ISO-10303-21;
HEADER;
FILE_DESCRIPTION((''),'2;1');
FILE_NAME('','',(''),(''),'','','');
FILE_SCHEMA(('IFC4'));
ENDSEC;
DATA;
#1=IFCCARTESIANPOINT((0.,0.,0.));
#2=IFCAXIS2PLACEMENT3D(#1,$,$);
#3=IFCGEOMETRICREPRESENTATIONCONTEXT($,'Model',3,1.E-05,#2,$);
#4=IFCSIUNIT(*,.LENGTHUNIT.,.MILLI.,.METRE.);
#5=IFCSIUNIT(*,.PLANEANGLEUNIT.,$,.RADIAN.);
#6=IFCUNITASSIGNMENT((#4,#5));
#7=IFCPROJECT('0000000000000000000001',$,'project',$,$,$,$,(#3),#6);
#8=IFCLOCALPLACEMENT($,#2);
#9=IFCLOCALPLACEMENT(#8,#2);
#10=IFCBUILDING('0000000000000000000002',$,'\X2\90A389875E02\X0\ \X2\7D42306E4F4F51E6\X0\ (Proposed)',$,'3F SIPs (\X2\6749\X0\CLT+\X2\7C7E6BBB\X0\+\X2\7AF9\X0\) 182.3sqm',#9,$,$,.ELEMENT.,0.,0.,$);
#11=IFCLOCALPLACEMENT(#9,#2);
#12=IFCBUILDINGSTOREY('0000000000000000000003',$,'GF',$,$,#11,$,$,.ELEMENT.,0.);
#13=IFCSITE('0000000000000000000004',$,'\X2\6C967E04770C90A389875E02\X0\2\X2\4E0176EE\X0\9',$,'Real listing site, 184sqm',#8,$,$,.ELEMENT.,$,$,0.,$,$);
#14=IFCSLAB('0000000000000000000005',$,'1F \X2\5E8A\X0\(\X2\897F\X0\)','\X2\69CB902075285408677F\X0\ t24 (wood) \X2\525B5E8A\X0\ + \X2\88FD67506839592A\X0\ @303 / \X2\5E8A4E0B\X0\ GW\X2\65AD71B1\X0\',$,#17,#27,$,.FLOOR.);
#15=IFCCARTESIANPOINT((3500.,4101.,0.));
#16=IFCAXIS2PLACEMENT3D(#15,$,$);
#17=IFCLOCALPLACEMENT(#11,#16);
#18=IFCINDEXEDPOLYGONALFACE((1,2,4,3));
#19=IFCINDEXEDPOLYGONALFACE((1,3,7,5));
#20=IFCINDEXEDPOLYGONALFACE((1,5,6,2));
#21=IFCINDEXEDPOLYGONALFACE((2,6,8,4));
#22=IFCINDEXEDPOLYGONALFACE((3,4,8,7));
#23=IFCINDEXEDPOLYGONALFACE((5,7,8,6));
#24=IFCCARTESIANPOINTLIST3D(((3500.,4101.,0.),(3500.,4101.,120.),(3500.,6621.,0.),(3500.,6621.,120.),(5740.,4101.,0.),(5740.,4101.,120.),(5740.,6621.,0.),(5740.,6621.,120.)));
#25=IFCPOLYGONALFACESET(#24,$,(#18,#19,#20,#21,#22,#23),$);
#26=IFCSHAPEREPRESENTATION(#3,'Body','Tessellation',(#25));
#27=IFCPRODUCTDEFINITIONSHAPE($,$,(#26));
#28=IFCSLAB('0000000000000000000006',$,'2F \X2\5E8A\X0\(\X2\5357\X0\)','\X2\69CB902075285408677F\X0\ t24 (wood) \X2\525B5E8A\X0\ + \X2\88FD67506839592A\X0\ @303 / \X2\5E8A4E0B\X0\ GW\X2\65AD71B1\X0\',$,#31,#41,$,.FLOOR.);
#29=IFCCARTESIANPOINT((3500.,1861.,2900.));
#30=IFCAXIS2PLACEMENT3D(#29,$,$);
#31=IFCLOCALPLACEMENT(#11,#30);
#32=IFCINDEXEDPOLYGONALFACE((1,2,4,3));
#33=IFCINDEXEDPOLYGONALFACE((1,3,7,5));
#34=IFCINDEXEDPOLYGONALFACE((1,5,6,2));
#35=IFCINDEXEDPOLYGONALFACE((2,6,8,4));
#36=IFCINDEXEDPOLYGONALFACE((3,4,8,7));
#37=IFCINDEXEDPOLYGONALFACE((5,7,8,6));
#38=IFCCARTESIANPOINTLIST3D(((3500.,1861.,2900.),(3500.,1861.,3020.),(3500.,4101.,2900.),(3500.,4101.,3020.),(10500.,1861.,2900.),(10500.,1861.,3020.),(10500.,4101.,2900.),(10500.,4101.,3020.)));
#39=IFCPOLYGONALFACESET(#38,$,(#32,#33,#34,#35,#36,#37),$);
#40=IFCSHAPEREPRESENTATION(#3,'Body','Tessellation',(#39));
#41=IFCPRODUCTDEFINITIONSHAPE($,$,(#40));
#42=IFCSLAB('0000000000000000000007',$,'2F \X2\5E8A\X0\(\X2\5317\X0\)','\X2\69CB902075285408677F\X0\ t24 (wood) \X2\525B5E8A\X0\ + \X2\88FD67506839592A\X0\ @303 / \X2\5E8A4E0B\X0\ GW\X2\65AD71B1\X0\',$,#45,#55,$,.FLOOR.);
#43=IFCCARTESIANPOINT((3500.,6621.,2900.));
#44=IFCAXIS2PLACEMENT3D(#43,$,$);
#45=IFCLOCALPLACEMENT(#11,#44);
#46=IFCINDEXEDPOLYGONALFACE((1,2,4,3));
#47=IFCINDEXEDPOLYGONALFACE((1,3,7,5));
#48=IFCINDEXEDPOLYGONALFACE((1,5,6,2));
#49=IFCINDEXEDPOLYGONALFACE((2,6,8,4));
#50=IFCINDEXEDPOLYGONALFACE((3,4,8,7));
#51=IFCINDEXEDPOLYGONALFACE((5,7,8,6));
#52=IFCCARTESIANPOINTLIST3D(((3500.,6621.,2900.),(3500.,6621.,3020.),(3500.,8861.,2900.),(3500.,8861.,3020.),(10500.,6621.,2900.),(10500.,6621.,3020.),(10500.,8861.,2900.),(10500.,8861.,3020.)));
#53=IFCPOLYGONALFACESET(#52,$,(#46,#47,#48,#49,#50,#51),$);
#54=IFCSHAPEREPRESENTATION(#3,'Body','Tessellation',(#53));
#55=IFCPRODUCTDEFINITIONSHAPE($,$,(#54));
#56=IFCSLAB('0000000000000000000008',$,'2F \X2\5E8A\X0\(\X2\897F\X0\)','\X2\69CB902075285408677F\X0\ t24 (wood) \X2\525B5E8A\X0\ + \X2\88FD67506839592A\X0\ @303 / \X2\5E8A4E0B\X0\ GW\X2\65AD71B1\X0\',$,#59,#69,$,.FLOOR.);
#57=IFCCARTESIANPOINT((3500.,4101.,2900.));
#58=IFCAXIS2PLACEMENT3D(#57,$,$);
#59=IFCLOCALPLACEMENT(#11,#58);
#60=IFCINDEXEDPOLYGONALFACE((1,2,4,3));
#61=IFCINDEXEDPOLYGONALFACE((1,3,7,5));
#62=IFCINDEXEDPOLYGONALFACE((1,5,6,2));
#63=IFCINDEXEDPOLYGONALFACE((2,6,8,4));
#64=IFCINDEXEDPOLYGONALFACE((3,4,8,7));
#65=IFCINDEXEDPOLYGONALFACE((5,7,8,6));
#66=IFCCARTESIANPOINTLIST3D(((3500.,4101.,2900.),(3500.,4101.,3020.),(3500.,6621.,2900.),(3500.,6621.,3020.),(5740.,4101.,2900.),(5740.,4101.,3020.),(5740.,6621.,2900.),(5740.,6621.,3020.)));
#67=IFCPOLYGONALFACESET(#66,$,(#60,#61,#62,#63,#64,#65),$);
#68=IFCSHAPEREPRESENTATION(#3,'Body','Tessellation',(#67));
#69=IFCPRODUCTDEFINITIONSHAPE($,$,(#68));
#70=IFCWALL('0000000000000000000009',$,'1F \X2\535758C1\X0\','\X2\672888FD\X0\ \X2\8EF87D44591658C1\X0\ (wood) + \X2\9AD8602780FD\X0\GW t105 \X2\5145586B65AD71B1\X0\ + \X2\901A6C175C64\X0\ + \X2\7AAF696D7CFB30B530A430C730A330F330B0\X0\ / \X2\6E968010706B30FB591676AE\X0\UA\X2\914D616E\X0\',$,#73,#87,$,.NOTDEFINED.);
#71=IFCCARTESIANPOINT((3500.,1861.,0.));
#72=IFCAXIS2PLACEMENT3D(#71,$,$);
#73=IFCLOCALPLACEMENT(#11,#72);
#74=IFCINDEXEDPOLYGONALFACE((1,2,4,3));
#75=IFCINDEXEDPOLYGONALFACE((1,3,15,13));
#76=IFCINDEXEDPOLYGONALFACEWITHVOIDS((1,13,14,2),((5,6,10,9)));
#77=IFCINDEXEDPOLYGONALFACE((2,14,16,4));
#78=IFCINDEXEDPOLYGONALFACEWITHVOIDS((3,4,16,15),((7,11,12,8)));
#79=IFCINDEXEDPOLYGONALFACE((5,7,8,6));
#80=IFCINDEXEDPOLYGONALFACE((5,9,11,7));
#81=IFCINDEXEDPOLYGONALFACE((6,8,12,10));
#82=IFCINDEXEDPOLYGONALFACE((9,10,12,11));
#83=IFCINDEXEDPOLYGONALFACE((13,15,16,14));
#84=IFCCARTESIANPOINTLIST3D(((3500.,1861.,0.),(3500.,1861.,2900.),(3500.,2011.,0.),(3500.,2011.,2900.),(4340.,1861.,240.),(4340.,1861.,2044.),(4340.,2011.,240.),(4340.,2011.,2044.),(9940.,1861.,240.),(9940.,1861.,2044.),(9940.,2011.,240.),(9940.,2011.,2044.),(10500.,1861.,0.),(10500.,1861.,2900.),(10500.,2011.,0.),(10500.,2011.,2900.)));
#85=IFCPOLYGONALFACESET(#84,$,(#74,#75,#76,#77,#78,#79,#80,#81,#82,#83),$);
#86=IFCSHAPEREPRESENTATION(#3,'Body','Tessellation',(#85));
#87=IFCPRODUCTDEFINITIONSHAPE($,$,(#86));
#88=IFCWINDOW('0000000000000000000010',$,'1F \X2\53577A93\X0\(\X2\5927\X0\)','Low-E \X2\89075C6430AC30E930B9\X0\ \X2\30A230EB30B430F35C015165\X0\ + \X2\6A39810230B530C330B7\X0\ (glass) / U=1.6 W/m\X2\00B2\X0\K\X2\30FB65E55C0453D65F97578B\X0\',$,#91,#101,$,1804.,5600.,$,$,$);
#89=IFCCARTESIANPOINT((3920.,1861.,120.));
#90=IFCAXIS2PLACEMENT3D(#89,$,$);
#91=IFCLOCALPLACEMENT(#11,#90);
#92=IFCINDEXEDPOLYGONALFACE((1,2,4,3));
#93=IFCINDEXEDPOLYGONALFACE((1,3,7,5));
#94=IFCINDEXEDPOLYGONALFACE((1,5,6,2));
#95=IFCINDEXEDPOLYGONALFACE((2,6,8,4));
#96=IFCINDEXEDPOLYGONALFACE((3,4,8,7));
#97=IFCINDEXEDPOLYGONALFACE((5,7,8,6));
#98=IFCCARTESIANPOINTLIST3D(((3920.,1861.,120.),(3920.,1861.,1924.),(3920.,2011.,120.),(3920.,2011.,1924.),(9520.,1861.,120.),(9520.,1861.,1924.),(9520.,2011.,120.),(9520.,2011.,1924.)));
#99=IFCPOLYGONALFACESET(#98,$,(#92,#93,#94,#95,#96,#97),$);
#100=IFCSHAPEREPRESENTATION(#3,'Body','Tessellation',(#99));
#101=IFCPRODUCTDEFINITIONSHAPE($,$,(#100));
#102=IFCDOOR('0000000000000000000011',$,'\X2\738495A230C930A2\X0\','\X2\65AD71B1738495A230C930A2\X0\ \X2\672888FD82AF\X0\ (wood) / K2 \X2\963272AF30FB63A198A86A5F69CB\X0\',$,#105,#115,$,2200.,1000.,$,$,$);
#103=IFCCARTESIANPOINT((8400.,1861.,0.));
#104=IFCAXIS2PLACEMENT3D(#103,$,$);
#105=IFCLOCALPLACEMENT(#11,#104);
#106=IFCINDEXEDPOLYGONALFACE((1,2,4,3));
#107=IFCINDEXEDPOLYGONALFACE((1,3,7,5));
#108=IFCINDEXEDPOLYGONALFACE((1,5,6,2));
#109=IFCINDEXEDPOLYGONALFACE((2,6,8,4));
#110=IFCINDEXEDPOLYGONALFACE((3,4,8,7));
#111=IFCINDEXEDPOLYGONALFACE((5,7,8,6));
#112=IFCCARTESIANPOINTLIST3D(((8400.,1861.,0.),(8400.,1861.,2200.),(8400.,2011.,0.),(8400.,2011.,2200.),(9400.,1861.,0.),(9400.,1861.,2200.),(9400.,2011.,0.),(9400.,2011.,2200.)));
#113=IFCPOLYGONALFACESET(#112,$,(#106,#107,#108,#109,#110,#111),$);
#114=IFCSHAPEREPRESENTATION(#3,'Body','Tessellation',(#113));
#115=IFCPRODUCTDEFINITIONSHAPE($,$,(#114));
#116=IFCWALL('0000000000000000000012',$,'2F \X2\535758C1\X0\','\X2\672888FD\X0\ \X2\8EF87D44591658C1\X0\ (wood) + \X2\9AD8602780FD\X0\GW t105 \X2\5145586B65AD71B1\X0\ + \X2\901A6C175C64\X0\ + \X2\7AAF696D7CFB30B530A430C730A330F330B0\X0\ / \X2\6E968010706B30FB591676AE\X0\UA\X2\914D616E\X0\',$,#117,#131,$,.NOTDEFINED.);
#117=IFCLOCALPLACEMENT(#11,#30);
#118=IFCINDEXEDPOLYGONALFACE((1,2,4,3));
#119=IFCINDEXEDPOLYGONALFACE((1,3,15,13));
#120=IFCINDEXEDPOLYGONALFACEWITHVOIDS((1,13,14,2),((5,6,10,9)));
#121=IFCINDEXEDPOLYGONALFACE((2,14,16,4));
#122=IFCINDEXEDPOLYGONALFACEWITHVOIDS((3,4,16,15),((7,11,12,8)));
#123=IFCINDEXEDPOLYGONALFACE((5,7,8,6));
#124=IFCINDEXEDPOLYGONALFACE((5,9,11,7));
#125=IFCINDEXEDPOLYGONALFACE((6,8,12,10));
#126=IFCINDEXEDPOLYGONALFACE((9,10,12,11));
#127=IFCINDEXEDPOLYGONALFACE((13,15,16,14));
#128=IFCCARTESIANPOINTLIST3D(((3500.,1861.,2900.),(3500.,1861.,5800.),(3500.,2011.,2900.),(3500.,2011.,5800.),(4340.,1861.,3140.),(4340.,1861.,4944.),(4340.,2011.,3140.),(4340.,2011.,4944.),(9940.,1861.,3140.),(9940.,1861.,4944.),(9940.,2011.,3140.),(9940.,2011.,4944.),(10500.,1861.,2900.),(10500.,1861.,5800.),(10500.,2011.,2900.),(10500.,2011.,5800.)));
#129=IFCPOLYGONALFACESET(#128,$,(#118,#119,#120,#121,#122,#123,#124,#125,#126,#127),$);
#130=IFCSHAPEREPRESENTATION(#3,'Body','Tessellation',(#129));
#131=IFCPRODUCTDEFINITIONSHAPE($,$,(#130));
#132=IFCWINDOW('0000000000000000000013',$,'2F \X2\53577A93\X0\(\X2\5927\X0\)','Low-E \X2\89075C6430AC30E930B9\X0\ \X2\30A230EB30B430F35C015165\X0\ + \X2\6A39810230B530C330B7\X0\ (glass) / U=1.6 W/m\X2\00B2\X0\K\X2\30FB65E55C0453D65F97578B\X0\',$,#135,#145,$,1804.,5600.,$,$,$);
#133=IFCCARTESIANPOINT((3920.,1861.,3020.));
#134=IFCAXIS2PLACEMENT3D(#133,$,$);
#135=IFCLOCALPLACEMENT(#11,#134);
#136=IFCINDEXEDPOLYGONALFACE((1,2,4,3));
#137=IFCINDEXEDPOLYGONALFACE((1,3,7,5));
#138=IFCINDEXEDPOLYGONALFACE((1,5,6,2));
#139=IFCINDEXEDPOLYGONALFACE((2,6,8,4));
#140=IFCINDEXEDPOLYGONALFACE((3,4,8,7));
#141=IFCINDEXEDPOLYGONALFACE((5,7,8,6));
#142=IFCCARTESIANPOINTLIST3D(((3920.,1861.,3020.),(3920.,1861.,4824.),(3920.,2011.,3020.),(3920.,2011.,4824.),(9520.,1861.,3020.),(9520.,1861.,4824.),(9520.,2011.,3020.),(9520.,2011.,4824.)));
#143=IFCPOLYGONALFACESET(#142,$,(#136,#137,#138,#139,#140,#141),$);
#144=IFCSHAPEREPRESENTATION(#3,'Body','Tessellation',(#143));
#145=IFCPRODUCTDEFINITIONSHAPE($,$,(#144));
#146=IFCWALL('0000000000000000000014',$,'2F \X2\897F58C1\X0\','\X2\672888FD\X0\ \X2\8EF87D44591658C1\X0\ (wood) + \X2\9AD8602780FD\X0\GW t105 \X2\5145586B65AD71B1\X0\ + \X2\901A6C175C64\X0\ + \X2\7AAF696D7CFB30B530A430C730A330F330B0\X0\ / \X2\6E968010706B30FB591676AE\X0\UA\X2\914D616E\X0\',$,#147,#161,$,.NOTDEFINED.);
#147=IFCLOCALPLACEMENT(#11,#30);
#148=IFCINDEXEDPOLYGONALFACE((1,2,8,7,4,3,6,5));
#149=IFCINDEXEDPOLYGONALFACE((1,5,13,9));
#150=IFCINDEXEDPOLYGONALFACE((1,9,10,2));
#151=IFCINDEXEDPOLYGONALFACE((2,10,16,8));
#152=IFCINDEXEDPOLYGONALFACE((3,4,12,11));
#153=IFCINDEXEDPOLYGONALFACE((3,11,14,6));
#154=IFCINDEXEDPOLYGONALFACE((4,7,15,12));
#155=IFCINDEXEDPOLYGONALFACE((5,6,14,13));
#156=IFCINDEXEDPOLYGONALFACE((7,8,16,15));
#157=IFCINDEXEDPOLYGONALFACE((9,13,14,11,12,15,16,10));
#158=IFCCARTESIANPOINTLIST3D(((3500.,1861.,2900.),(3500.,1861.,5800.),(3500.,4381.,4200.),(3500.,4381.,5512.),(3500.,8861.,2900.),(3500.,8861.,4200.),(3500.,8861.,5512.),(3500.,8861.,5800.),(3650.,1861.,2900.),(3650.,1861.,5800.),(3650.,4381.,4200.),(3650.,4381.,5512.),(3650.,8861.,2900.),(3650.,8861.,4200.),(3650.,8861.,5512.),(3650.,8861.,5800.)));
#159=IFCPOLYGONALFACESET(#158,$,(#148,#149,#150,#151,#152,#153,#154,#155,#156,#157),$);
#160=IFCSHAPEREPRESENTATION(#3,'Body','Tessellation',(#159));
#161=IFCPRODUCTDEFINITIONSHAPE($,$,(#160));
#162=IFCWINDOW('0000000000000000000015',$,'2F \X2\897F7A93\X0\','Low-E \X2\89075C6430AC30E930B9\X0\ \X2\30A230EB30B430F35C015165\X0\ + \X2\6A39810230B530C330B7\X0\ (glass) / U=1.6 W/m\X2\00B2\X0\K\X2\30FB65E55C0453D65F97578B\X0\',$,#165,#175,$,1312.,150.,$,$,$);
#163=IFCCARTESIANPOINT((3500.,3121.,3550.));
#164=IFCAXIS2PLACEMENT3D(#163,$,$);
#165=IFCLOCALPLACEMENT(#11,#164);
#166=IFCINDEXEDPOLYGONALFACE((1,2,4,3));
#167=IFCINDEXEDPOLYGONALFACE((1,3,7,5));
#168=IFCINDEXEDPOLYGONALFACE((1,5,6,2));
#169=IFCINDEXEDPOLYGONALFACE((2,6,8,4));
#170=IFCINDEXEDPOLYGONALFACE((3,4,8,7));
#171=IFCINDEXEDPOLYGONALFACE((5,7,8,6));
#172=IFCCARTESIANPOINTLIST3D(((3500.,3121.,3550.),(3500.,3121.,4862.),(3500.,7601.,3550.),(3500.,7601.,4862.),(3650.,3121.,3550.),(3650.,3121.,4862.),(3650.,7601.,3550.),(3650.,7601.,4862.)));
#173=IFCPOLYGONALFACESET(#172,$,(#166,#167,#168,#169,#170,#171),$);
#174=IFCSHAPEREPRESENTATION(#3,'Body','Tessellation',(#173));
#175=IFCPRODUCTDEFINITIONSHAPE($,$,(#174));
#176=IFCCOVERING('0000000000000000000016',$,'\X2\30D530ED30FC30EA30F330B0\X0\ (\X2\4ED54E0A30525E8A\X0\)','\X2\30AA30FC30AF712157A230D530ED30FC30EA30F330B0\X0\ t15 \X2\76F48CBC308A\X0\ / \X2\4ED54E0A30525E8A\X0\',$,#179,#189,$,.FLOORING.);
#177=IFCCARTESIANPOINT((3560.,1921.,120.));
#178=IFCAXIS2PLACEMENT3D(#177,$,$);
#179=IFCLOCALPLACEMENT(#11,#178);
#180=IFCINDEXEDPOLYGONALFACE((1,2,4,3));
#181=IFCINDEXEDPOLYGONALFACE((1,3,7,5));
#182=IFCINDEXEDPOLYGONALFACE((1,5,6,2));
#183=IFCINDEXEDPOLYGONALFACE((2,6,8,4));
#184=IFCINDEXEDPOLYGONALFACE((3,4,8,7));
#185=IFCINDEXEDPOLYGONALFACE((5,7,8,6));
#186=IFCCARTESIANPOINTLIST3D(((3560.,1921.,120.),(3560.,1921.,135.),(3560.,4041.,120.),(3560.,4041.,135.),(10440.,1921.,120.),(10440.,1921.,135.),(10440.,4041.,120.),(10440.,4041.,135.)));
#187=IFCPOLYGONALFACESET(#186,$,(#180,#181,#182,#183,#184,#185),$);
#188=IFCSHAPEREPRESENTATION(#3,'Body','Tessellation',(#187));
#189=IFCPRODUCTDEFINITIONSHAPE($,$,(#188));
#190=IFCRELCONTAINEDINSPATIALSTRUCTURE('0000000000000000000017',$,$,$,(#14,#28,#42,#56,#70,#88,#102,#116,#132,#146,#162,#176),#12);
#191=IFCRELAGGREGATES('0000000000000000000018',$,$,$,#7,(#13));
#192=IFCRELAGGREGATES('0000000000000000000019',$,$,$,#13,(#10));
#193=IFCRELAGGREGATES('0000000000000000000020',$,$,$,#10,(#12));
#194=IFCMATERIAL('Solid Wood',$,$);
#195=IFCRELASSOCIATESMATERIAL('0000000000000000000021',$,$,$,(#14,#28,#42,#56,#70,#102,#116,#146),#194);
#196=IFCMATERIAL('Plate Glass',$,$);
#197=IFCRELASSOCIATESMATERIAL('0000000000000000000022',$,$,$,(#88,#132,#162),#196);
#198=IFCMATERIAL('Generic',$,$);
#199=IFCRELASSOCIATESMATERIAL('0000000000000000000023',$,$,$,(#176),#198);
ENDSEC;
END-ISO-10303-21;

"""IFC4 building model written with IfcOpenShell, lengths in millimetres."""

from ifc_helpers import new_model, si_unit, frame, frame_2d, origin, place, context, project, spatial, rectangle, extrude, material, element, fill, save


model = new_model("IFC4")

# Units and contexts
model_context = context("Model", 3, precision=1e-05, world=origin())
ifc_project = project(units=[si_unit("LENGTHUNIT", "METRE", prefix="MILLI"), si_unit("PLANEANGLEUNIT", "RADIAN")], contexts=[model_context])

# Site, building, storey
site_placement = place(None, origin())
site = spatial("IfcSite", under=ifc_project, at=site_placement, Name="沖縄県那覇市2丁目9", ObjectType="Real listing site, 184sqm", CompositionType="ELEMENT", RefElevation=0.0)
building_placement = place(site_placement, origin())
building = spatial("IfcBuilding", under=site, at=building_placement, Name="那覇市 終の住処 (Proposed)", ObjectType="3F SIPs (杉CLT+籾殻+竹) 182.3sqm", CompositionType="ELEMENT", ElevationOfRefHeight=0.0, ElevationOfTerrain=0.0)
storey_placement = place(building_placement, origin())
storey = spatial("IfcBuildingStorey", under=building, at=storey_placement, Name="GF", CompositionType="ELEMENT", Elevation=0.0)

# Slabs
ifc_material_1 = material(Name="Solid Wood")
slab_1_placement = place(storey_placement, frame((3500.0, 4101.0, 0.0)))
element("IfcSlab", 1, at=slab_1_placement, inside=storey, material=ifc_material_1, Name="1F 床(西)", Description="構造用合板 t24 (wood) 剛床 + 製材根太 @303 / 床下 GW断熱", PredefinedType="FLOOR", context=model_context, shape_type="SweptSolid", body=[
    extrude(rectangle(XDim=2240.0, YDim=2520.0, at=frame_2d((1120.0, 1260.0))), frame((3500.0, 4101.0, 0.0)), (0.0, 0.0, 1.0), 120.0),
])
slab_2_placement = place(storey_placement, frame((3500.0, 1861.0, 2900.0)))
element("IfcSlab", 2, at=slab_2_placement, inside=storey, material=ifc_material_1, Name="2F 床(南)", Description="構造用合板 t24 (wood) 剛床 + 製材根太 @303 / 床下 GW断熱", PredefinedType="FLOOR", context=model_context, shape_type="SweptSolid", body=[
    extrude(rectangle(XDim=7000.0, YDim=2240.0, at=frame_2d((3500.0, 1120.0))), frame((3500.0, 1861.0, 2900.0)), (0.0, 0.0, 1.0), 120.0),
])
slab_3_placement = place(storey_placement, frame((3500.0, 6621.0, 2900.0)))
element("IfcSlab", 3, at=slab_3_placement, inside=storey, material=ifc_material_1, Name="2F 床(北)", Description="構造用合板 t24 (wood) 剛床 + 製材根太 @303 / 床下 GW断熱", PredefinedType="FLOOR", context=model_context, shape_type="SweptSolid", body=[
    extrude(rectangle(XDim=7000.0, YDim=2240.0, at=frame_2d((3500.0, 1120.0))), frame((3500.0, 6621.0, 2900.0)), (0.0, 0.0, 1.0), 120.0),
])
slab_4_placement = place(storey_placement, frame((3500.0, 4101.0, 2900.0)))
element("IfcSlab", 4, at=slab_4_placement, inside=storey, material=ifc_material_1, Name="2F 床(西)", Description="構造用合板 t24 (wood) 剛床 + 製材根太 @303 / 床下 GW断熱", PredefinedType="FLOOR", context=model_context, shape_type="SweptSolid", body=[
    extrude(rectangle(XDim=2240.0, YDim=2520.0, at=frame_2d((1120.0, 1260.0))), frame((3500.0, 4101.0, 2900.0)), (0.0, 0.0, 1.0), 120.0),
])

# Wall, openings, window, door
wall_1_placement = place(storey_placement, frame((3500.0, 1861.0, 0.0)))
wall_1 = element("IfcWall", 5, at=wall_1_placement, inside=storey, material=ifc_material_1, Name="1F 南壁", Description="木製 軸組外壁 (wood) + 高性能GW t105 充填断熱 + 通気層 + 窯業系サイディング / 準耐火・外皮UA配慮", PredefinedType="NOTDEFINED", context=model_context, shape_type="SweptSolid", body=[
    extrude(rectangle(XDim=7000.0, YDim=150.0, at=frame_2d((3500.0, 75.0))), frame((3500.0, 1861.0, 0.0)), (0.0, 0.0, 1.0), 2900.0),
])
opening_1_placement = place(storey_placement, frame((3920.0, 1861.0, 120.0)))
opening_1 = element("IfcOpeningElement", 6, at=opening_1_placement, cuts=wall_1, PredefinedType="NOTDEFINED", context=model_context, shape_type="SweptSolid", body=[
    extrude(rectangle(XDim=5600.0, YDim=150.0, at=frame_2d((2800.0, 75.0))), frame((3920.0, 1861.0, 120.0)), (0.0, 0.0, 1.0), 1804.0),
])
opening_2_placement = place(storey_placement, frame((8400.0, 1861.0, 0.0)))
opening_2 = element("IfcOpeningElement", 7, at=opening_2_placement, cuts=wall_1, PredefinedType="NOTDEFINED", context=model_context, shape_type="SweptSolid", body=[
    extrude(rectangle(XDim=1000.0, YDim=150.0, at=frame_2d((500.0, 75.0))), frame((8400.0, 1861.0, 0.0)), (0.0, 0.0, 1.0), 2200.0),
])
ifc_material_2 = material(Name="Plate Glass")
window_1_placement = place(storey_placement, frame((3920.0, 1861.0, 120.0)))
window_1 = element("IfcWindow", 8, at=window_1_placement, inside=storey, material=ifc_material_2, Name="1F 南窓(大)", Description="Low-E 複層ガラス アルゴン封入 + 樹脂サッシ (glass) / U=1.6 W/m²K・日射取得型", OverallHeight=1804.0, OverallWidth=5600.0, context=model_context, shape_type="SweptSolid", body=[
    extrude(rectangle(XDim=5600.0, YDim=150.0, at=frame_2d((2800.0, 75.0))), frame((3920.0, 1861.0, 120.0)), (0.0, 0.0, 1.0), 1804.0),
])
fill(opening_1, window_1)
door_placement = place(storey_placement, frame((8400.0, 1861.0, 0.0)))
door = element("IfcDoor", 9, at=door_placement, inside=storey, material=ifc_material_1, Name="玄関ドア", Description="断熱玄関ドア 木製芯 (wood) / K2 防犯・採風機構", OverallHeight=2200.0, OverallWidth=1000.0, context=model_context, shape_type="SweptSolid", body=[
    extrude(rectangle(XDim=1000.0, YDim=150.0, at=frame_2d((500.0, 75.0))), frame((8400.0, 1861.0, 0.0)), (0.0, 0.0, 1.0), 2200.0),
])
fill(opening_2, door)

# Wall, opening, window
wall_2_placement = place(storey_placement, frame((3500.0, 1861.0, 2900.0)))
wall_2 = element("IfcWall", 10, at=wall_2_placement, inside=storey, material=ifc_material_1, Name="2F 南壁", Description="木製 軸組外壁 (wood) + 高性能GW t105 充填断熱 + 通気層 + 窯業系サイディング / 準耐火・外皮UA配慮", PredefinedType="NOTDEFINED", context=model_context, shape_type="SweptSolid", body=[
    extrude(rectangle(XDim=7000.0, YDim=150.0, at=frame_2d((3500.0, 75.0))), frame((3500.0, 1861.0, 2900.0)), (0.0, 0.0, 1.0), 2900.0),
])
opening_3_placement = place(storey_placement, frame((3920.0, 1861.0, 3020.0)))
opening_3 = element("IfcOpeningElement", 11, at=opening_3_placement, cuts=wall_2, PredefinedType="NOTDEFINED", context=model_context, shape_type="SweptSolid", body=[
    extrude(rectangle(XDim=5600.0, YDim=150.0, at=frame_2d((2800.0, 75.0))), frame((3920.0, 1861.0, 3020.0)), (0.0, 0.0, 1.0), 1804.0),
])
window_2_placement = place(storey_placement, frame((3920.0, 1861.0, 3020.0)))
window_2 = element("IfcWindow", 12, at=window_2_placement, inside=storey, material=ifc_material_2, Name="2F 南窓(大)", Description="Low-E 複層ガラス アルゴン封入 + 樹脂サッシ (glass) / U=1.6 W/m²K・日射取得型", OverallHeight=1804.0, OverallWidth=5600.0, context=model_context, shape_type="SweptSolid", body=[
    extrude(rectangle(XDim=5600.0, YDim=150.0, at=frame_2d((2800.0, 75.0))), frame((3920.0, 1861.0, 3020.0)), (0.0, 0.0, 1.0), 1804.0),
])
fill(opening_3, window_2)

# Wall, opening, window
wall_3_placement = place(storey_placement, frame((3500.0, 1861.0, 2900.0)))
wall_3 = element("IfcWall", 13, at=wall_3_placement, inside=storey, material=ifc_material_1, Name="2F 西壁", Description="木製 軸組外壁 (wood) + 高性能GW t105 充填断熱 + 通気層 + 窯業系サイディング / 準耐火・外皮UA配慮", PredefinedType="NOTDEFINED", context=model_context, shape_type="SweptSolid", body=[
    extrude(rectangle(XDim=150.0, YDim=7000.0, at=frame_2d((75.0, 3500.0))), frame((3500.0, 1861.0, 2900.0)), (0.0, 0.0, 1.0), 2900.0),
])
opening_4_placement = place(storey_placement, frame((3500.0, 3121.0, 3550.0)))
opening_4 = element("IfcOpeningElement", 14, at=opening_4_placement, cuts=wall_3, PredefinedType="NOTDEFINED", context=model_context, shape_type="SweptSolid", body=[
    extrude(rectangle(XDim=150.0, YDim=4480.0, at=frame_2d((75.0, 2240.0))), frame((3500.0, 3121.0, 3550.0)), (0.0, 0.0, 1.0), 1312.0),
])
window_3_placement = place(storey_placement, frame((3500.0, 3121.0, 3550.0)))
window_3 = element("IfcWindow", 15, at=window_3_placement, inside=storey, material=ifc_material_2, Name="2F 西窓", Description="Low-E 複層ガラス アルゴン封入 + 樹脂サッシ (glass) / U=1.6 W/m²K・日射取得型", OverallHeight=1312.0, OverallWidth=150.0, context=model_context, shape_type="SweptSolid", body=[
    extrude(rectangle(XDim=150.0, YDim=4480.0, at=frame_2d((75.0, 2240.0))), frame((3500.0, 3121.0, 3550.0)), (0.0, 0.0, 1.0), 1312.0),
])
fill(opening_4, window_3)

# Covering
ifc_material_3 = material(Name="Generic")
covering_1_placement = place(storey_placement, frame((3560.0, 1921.0, 120.0)))
element("IfcCovering", 16, at=covering_1_placement, inside=storey, material=ifc_material_3, Name="フローリング (仕上げ床)", Description="オーク無垢フローリング t15 直貼り / 仕上げ床", PredefinedType="FLOORING", context=model_context, shape_type="SweptSolid", body=[
    extrude(rectangle(XDim=6880.0, YDim=2120.0, at=frame_2d((3440.0, 1060.0))), frame((3560.0, 1921.0, 120.0)), (0.0, 0.0, 1.0), 15.0),
])

save(model, "model.ifc")
